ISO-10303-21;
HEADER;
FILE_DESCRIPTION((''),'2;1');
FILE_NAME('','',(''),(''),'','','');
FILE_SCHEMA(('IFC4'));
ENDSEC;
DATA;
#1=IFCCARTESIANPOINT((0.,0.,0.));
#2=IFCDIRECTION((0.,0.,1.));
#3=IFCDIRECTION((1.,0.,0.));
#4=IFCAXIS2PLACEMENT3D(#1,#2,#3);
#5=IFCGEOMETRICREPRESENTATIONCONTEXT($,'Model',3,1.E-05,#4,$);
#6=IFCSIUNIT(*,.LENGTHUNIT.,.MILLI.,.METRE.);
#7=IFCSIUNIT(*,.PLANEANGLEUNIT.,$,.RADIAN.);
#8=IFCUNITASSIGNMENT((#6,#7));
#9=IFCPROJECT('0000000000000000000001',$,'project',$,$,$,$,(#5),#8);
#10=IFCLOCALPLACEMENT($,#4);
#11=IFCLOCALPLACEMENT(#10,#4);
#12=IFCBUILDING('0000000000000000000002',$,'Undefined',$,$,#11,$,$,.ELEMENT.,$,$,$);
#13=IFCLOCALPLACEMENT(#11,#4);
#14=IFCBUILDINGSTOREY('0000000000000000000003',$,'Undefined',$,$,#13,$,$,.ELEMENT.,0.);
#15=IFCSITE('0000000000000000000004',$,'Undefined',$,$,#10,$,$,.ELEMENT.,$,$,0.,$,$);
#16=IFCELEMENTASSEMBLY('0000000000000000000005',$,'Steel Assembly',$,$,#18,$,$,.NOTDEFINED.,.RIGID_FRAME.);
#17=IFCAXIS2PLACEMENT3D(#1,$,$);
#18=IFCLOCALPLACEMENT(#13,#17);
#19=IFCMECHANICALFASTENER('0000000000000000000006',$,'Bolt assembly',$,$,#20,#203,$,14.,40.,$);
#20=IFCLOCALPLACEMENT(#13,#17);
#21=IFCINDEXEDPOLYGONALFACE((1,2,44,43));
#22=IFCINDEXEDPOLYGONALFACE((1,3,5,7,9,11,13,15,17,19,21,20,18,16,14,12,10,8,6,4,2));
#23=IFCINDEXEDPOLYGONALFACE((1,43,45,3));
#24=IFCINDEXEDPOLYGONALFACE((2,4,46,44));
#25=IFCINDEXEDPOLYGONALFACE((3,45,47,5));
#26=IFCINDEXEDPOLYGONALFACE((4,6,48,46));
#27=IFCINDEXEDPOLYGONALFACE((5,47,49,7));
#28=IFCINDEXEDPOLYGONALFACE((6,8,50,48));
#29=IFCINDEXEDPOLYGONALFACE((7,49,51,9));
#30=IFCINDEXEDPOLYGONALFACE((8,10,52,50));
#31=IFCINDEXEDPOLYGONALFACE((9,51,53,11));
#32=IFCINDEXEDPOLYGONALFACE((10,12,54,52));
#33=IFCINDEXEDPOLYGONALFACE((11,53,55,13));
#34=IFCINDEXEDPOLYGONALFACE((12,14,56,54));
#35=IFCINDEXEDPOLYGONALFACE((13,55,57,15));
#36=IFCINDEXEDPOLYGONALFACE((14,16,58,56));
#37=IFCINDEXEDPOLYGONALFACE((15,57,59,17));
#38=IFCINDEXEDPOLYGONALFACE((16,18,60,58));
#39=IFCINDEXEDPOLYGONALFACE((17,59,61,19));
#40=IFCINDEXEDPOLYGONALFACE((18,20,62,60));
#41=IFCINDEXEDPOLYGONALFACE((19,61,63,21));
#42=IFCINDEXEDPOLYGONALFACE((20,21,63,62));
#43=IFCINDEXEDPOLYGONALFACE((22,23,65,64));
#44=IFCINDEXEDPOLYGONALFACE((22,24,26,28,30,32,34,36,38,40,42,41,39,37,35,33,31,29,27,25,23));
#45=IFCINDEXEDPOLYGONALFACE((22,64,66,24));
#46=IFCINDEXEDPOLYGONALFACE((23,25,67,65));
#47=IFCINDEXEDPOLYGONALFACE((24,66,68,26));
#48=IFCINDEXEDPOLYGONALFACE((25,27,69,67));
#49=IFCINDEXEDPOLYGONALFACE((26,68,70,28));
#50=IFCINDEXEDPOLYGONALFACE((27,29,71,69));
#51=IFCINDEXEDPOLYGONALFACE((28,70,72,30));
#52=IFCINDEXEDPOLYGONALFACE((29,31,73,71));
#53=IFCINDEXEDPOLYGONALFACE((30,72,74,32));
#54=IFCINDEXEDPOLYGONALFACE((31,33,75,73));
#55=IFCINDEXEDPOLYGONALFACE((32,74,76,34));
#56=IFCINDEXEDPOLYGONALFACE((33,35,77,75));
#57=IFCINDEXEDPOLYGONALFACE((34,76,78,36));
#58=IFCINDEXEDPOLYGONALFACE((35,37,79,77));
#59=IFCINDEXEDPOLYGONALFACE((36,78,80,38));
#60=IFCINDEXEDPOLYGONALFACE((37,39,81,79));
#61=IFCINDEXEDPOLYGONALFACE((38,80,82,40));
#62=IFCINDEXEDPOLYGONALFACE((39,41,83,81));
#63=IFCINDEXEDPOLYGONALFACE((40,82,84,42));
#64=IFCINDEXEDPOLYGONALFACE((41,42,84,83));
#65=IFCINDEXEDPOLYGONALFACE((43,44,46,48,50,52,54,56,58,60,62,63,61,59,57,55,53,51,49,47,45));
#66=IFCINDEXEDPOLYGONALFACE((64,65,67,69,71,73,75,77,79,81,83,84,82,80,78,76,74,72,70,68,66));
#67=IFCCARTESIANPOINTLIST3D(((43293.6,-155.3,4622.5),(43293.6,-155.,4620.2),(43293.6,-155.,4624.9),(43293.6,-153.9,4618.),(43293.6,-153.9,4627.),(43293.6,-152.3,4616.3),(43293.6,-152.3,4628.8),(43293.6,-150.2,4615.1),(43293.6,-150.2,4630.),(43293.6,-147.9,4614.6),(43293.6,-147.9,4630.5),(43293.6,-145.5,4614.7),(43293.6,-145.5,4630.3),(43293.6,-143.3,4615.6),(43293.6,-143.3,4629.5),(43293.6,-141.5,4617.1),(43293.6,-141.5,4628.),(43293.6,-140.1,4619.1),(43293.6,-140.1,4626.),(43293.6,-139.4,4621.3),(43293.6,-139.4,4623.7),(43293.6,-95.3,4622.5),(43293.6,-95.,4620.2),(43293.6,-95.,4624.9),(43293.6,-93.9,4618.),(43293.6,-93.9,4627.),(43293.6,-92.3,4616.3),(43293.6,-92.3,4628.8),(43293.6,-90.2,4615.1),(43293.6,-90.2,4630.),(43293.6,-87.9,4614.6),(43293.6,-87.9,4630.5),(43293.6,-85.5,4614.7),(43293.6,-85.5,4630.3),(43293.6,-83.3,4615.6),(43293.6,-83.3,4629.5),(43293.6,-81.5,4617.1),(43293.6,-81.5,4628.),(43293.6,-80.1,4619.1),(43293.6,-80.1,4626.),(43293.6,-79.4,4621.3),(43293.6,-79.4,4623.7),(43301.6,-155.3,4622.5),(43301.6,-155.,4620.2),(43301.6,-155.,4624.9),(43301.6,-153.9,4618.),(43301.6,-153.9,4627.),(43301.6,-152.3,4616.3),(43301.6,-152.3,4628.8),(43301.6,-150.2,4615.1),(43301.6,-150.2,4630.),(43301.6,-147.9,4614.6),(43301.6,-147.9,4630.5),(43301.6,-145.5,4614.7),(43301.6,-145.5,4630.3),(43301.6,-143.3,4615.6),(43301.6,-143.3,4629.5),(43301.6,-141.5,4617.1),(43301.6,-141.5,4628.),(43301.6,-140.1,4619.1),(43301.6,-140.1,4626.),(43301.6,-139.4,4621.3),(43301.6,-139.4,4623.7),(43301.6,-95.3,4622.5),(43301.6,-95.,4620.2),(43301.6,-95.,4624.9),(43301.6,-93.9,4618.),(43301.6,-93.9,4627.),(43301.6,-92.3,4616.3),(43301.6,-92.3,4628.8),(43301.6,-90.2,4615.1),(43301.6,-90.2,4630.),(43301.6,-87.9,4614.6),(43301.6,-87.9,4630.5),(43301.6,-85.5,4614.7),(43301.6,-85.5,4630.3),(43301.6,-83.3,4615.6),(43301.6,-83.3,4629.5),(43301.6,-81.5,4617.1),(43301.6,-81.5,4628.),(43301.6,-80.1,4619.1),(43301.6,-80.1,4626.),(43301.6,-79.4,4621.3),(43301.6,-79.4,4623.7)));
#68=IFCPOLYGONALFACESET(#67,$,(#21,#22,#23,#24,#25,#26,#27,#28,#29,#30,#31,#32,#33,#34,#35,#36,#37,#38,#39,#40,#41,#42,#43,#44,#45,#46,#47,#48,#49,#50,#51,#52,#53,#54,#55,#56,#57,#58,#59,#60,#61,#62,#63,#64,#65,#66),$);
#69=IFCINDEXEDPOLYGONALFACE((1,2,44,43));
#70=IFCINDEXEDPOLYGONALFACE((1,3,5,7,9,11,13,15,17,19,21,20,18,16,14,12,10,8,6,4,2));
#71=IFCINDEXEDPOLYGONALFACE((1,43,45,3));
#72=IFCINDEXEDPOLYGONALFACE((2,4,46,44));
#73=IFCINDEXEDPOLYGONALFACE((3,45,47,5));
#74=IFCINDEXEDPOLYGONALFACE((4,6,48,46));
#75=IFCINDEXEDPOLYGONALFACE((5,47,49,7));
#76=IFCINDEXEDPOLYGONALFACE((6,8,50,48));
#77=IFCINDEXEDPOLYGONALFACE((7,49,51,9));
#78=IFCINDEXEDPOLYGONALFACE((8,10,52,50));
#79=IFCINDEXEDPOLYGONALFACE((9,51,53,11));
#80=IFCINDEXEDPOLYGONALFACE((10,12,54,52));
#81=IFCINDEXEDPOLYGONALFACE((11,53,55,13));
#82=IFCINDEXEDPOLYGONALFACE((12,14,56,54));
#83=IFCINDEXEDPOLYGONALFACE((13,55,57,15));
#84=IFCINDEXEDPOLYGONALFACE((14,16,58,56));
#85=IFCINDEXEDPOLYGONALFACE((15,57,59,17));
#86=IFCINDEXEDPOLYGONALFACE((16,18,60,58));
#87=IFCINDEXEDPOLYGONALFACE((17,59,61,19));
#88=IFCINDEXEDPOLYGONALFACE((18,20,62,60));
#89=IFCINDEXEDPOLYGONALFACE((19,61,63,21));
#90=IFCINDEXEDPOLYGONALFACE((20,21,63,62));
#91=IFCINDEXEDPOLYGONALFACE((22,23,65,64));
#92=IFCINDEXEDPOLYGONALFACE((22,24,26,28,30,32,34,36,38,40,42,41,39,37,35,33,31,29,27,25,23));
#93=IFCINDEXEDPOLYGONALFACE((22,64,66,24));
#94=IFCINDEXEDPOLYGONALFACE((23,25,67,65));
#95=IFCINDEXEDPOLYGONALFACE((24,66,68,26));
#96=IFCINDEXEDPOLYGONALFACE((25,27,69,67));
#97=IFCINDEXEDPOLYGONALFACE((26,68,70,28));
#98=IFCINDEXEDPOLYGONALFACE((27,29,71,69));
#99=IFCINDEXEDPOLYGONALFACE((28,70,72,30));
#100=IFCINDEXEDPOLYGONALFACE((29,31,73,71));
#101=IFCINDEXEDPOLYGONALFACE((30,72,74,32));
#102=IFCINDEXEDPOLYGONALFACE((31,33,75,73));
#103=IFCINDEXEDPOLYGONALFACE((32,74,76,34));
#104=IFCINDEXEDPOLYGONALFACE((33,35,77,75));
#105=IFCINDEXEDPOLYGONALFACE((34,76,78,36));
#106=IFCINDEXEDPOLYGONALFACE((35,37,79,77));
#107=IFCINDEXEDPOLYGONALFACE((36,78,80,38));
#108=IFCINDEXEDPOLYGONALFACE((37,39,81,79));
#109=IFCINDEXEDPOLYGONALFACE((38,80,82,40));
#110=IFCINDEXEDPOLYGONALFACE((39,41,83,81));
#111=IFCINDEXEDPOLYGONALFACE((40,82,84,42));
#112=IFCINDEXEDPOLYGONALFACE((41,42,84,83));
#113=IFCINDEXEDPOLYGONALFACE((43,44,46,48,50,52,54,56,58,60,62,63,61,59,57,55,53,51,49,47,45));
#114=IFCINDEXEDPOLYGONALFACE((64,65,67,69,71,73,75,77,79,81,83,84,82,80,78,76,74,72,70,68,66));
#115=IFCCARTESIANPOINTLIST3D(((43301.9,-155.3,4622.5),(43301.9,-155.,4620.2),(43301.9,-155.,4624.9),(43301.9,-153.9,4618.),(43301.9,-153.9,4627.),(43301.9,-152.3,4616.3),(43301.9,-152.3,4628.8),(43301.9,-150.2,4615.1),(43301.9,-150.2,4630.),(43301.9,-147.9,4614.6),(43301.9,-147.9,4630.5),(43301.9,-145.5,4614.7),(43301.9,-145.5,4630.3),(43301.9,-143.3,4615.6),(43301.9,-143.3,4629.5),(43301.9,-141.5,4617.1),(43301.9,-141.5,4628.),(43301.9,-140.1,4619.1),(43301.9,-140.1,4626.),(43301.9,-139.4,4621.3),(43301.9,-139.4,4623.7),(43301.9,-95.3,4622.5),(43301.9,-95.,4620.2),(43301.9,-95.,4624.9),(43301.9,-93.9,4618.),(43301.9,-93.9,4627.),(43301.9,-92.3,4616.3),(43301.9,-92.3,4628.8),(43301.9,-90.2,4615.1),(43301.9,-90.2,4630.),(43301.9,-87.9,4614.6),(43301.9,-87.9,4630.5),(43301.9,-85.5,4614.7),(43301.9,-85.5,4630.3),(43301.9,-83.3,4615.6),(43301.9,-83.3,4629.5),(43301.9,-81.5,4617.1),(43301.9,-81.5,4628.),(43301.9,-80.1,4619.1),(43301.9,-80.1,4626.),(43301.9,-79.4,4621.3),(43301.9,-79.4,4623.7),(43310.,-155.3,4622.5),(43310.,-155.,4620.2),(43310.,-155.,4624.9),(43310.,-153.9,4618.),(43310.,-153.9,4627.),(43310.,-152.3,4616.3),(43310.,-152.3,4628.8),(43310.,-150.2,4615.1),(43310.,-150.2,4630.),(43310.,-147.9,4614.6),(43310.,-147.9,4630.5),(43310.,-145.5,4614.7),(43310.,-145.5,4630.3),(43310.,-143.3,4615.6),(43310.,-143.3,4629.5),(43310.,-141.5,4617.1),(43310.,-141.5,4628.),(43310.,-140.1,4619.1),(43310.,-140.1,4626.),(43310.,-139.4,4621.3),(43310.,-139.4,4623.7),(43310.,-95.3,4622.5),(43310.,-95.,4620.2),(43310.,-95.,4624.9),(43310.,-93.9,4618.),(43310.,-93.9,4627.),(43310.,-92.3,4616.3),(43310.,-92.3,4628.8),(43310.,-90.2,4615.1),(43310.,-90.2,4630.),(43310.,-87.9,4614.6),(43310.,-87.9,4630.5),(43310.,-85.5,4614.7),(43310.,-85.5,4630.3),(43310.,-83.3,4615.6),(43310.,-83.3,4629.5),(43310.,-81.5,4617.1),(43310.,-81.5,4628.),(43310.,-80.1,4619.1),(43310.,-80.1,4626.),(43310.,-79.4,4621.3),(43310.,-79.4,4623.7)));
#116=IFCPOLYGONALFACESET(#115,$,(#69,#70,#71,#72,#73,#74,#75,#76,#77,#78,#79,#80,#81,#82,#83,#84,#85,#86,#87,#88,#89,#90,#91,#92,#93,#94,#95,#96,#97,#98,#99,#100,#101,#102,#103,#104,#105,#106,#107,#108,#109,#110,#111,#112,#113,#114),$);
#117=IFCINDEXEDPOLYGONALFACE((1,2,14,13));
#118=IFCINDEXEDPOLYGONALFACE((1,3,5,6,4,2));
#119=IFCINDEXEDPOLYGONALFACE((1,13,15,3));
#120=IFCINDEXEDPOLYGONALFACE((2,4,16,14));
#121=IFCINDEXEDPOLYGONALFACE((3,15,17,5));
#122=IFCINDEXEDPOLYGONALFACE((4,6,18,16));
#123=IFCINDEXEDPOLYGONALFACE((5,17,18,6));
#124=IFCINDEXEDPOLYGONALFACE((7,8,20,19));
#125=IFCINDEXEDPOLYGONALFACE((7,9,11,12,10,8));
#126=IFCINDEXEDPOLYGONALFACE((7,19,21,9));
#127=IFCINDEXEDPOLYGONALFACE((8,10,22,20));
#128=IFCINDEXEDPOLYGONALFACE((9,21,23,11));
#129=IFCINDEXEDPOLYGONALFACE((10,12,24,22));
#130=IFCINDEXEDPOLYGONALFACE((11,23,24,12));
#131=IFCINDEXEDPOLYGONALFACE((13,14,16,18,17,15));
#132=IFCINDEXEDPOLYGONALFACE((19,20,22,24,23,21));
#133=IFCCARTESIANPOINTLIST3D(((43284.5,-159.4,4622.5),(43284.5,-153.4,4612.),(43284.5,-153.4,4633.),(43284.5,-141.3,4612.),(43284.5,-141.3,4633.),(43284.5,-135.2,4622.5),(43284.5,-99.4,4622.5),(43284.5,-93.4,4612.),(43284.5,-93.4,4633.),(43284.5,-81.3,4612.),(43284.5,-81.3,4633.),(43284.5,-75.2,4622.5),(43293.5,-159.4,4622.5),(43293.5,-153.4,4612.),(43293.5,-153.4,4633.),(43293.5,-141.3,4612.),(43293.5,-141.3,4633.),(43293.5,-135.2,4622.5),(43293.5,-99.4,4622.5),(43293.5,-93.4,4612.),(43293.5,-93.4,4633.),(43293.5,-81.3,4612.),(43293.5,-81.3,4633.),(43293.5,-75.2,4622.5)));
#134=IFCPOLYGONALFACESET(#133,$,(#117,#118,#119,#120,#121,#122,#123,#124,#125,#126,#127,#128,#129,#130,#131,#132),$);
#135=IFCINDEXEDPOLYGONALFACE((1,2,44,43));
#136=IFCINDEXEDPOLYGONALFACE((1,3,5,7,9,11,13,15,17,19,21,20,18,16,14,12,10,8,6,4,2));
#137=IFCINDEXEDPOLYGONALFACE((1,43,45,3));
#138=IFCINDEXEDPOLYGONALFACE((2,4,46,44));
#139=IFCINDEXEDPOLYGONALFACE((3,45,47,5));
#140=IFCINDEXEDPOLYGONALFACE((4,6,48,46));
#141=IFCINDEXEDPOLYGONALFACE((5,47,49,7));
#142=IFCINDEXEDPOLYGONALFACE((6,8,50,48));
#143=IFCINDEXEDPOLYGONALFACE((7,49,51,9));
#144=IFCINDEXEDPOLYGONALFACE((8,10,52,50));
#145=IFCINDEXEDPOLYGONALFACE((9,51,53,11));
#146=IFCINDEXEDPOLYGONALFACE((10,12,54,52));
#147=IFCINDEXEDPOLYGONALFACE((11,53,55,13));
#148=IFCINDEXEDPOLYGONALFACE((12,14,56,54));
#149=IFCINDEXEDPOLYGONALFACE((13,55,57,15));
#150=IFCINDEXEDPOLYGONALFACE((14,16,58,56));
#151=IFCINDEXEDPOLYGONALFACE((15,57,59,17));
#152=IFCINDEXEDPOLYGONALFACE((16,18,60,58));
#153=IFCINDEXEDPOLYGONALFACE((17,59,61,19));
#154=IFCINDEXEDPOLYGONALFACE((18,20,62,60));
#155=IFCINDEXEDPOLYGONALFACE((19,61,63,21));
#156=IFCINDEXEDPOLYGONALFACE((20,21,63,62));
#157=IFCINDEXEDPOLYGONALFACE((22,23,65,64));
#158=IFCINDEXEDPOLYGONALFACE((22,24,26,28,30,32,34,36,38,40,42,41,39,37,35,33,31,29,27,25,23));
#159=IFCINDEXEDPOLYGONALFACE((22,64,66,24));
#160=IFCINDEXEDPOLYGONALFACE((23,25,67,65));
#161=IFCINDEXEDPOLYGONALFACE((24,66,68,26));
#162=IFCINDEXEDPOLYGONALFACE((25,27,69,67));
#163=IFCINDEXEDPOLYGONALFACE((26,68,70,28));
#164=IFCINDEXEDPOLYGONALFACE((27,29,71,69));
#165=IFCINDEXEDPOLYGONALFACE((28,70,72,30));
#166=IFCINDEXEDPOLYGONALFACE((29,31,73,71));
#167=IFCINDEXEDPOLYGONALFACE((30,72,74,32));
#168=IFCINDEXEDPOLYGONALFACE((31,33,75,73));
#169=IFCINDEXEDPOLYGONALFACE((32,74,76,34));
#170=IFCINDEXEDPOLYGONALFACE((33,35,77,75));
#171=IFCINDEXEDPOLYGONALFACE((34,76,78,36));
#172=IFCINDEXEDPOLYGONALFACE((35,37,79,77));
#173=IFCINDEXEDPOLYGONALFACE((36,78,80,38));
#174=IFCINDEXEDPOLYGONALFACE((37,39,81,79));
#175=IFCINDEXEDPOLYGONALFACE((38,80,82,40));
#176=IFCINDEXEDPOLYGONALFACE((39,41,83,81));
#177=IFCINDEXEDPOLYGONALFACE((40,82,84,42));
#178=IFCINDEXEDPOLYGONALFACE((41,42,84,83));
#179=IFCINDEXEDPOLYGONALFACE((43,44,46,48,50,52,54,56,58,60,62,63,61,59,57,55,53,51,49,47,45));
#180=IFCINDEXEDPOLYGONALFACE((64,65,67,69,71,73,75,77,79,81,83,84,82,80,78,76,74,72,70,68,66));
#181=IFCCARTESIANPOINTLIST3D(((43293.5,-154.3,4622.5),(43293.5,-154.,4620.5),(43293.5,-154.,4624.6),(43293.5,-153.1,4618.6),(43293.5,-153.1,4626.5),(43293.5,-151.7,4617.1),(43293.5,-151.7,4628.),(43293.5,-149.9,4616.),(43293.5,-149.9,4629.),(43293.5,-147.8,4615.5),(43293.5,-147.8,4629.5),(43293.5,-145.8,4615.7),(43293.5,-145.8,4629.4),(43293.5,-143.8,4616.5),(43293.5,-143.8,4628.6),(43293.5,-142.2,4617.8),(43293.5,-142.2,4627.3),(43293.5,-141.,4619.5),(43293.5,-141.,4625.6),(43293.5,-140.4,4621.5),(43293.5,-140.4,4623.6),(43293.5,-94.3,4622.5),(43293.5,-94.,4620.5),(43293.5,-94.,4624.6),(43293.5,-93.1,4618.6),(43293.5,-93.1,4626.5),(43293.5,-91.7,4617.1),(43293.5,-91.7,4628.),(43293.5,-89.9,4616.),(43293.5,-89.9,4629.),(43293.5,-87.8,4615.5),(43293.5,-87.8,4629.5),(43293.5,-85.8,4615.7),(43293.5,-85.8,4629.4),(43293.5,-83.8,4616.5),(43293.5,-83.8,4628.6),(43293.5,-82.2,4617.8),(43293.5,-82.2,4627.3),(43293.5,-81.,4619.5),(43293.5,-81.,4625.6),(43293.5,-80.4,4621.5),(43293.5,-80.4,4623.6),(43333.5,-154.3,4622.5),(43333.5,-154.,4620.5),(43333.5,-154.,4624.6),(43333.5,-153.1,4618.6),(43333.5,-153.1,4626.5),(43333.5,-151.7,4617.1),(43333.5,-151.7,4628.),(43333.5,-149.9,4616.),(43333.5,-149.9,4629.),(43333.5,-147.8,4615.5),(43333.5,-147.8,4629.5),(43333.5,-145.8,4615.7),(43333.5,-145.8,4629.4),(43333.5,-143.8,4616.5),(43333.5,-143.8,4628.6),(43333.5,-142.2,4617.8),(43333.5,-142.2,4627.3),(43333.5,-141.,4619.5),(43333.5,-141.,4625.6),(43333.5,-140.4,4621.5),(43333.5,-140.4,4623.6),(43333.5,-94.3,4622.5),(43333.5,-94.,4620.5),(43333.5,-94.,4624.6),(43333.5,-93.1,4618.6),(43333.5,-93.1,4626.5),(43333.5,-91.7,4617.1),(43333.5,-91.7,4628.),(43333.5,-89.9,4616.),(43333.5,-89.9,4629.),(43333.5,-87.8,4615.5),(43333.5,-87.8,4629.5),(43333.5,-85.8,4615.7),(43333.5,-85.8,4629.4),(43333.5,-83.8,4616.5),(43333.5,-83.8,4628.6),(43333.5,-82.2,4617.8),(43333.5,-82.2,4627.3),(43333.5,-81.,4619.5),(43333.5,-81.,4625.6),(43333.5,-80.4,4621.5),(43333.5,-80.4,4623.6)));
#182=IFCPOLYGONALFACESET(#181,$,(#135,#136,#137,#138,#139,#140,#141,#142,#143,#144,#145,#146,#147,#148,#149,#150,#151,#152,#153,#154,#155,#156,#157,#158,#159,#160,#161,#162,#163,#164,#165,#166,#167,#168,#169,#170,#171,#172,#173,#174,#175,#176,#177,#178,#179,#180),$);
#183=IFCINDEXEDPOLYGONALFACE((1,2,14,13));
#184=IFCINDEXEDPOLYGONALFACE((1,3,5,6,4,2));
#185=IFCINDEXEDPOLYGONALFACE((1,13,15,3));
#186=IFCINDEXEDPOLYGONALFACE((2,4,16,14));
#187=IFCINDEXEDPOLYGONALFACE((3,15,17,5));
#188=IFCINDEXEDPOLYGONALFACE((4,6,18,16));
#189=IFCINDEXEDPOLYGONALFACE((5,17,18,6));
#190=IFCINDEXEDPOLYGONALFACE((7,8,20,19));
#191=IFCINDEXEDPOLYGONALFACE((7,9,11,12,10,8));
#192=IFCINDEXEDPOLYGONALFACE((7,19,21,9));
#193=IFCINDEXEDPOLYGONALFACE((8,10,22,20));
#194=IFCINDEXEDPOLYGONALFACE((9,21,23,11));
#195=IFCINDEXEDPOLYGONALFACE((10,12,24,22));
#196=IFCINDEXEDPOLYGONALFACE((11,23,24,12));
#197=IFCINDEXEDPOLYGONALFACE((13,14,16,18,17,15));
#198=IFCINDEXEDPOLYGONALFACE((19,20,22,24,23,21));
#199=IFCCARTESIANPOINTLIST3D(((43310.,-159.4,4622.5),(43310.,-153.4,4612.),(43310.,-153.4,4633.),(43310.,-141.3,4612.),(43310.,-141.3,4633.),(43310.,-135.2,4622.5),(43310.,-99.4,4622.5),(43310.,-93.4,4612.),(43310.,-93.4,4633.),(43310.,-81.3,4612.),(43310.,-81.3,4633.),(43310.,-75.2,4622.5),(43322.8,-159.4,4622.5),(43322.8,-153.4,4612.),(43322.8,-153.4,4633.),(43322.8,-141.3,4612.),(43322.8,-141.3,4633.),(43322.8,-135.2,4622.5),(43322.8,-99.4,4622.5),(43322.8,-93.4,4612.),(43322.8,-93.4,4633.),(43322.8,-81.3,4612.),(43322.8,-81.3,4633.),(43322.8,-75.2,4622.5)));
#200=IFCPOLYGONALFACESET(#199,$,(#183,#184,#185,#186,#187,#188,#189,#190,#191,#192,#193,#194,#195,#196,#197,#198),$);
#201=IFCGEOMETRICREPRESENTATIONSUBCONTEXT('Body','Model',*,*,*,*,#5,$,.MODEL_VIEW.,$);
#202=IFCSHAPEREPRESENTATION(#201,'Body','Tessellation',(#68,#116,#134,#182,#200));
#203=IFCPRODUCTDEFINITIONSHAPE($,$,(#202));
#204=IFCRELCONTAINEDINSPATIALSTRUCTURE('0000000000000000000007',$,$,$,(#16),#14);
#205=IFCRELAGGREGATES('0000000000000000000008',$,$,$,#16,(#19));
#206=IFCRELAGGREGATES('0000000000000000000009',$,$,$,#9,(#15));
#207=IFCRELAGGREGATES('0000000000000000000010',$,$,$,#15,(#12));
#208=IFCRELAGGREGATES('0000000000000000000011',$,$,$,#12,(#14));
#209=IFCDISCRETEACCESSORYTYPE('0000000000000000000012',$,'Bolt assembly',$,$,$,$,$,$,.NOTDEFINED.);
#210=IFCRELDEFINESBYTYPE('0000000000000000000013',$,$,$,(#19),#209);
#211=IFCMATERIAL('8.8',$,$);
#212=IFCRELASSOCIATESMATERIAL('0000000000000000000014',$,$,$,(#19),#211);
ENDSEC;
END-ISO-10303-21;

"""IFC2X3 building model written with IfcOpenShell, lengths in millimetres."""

from ifc_helpers import new_model, si_unit, frame, origin_with_axes, origin_2d_with_axis, place, context, subcontext, project, spatial, polyline, circle, outline, extrude, source, transform, mapped, material, type_object, element, aggregate, save


model = new_model("IFC2X3")

# Units and contexts
model_context = context("Model", 3, precision=1e-05, world=origin_with_axes())
body_context = subcontext(model_context, "Body", "Model", "MODEL_VIEW")
ifc_project = project(units=[si_unit("LENGTHUNIT", "METRE", prefix="MILLI"), si_unit("PLANEANGLEUNIT", "RADIAN")], contexts=[model_context])

# Site, building, storey
site_placement = place(None, origin_with_axes())
site = spatial("IfcSite", under=ifc_project, at=site_placement, Name="Undefined", CompositionType="ELEMENT", RefElevation=0.0)
building_placement = place(site_placement, origin_with_axes())
building = spatial("IfcBuilding", under=site, at=building_placement, Name="Undefined", CompositionType="ELEMENT")
storey_placement = place(building_placement, origin_with_axes())
storey = spatial("IfcBuildingStorey", under=building, at=storey_placement, Name="Undefined", CompositionType="ELEMENT", Elevation=0.0)

# Shared definitions
discrete_accessory_type_1 = type_object("IfcDiscreteAccessoryType", Name="Bolt assembly")

# Shared definitions
ifc_material_1 = material(Name="8.8")

# Element assembly
assembly_1_placement = place(storey_placement, origin_with_axes())
assembly_1 = element("IfcElementAssembly", 1, at=assembly_1_placement, inside=storey, Name="Steel Assembly", AssemblyPlace="NOTDEFINED", PredefinedType="RIGID_FRAME")

# Mechanical fastener
shared_shape_1 = source(origin_with_axes(), body_context, "Body", "SweptSolid", [
    extrude(circle(Radius=8.0, at=origin_2d_with_axis()), frame((0.0, -7.9, 0.0), z_axis=(0.0, 1.0, 0.0), x_axis=(1.0, 0.0, 0.0)), (0.0, 0.0, 1.0), 8.0),
    extrude(circle(Radius=8.0, at=origin_2d_with_axis()), frame((0.0, 0.4, 0.0), z_axis=(0.0, 1.0, 0.0), x_axis=(1.0, 0.0, 0.0)), (0.0, 0.0, 1.0), 8.1),
    extrude(outline(polyline([(12.1, 0.0), (6.1, 10.5), (-6.1, 10.5), (-12.1, 0.0), (-6.1, -10.5), (6.1, -10.5), (12.1, 0.0)])), frame((0.0, -17.0, 0.0), z_axis=(0.0, 1.0, 0.0), x_axis=(1.0, 0.0, 0.0)), (0.0, 0.0, 1.0), 9.0),
    extrude(circle(Radius=7.0, at=origin_2d_with_axis()), frame((0.0, -8.0, 0.0), z_axis=(0.0, 1.0, 0.0), x_axis=(1.0, 0.0, 0.0)), (0.0, 0.0, 1.0), 40.0),
    extrude(outline(polyline([(12.1, 0.0), (6.1, 10.5), (-6.1, 10.5), (-12.1, 0.0), (-6.1, -10.5), (6.1, -10.5), (12.1, 0.0)])), frame((0.0, 8.5, 0.0), z_axis=(0.0, 1.0, 0.0), x_axis=(1.0, 0.0, 0.0)), (0.0, 0.0, 1.0), 12.8),
])
mechanical_fastener_1_placement = place(assembly_1_placement, frame((43301.5, -87.3, 4622.5), z_axis=(0.0, 0.0, 1.0), x_axis=(0.0, -1.0, 0.0)))
mechanical_fastener_1 = element("IfcMechanicalFastener", 2, at=mechanical_fastener_1_placement, type_object=discrete_accessory_type_1, material=ifc_material_1, Name="Bolt assembly", NominalDiameter=14.0, NominalLength=40.0, context=body_context, shape_type="MappedRepresentation", body=[
    mapped(shared_shape_1, transform((0.0, 0.0, 0.0))),
    mapped(shared_shape_1, transform((60.0, 0.0, 0.0))),
])
aggregate(assembly_1, [mechanical_fastener_1])

save(model, "model.ifc")
